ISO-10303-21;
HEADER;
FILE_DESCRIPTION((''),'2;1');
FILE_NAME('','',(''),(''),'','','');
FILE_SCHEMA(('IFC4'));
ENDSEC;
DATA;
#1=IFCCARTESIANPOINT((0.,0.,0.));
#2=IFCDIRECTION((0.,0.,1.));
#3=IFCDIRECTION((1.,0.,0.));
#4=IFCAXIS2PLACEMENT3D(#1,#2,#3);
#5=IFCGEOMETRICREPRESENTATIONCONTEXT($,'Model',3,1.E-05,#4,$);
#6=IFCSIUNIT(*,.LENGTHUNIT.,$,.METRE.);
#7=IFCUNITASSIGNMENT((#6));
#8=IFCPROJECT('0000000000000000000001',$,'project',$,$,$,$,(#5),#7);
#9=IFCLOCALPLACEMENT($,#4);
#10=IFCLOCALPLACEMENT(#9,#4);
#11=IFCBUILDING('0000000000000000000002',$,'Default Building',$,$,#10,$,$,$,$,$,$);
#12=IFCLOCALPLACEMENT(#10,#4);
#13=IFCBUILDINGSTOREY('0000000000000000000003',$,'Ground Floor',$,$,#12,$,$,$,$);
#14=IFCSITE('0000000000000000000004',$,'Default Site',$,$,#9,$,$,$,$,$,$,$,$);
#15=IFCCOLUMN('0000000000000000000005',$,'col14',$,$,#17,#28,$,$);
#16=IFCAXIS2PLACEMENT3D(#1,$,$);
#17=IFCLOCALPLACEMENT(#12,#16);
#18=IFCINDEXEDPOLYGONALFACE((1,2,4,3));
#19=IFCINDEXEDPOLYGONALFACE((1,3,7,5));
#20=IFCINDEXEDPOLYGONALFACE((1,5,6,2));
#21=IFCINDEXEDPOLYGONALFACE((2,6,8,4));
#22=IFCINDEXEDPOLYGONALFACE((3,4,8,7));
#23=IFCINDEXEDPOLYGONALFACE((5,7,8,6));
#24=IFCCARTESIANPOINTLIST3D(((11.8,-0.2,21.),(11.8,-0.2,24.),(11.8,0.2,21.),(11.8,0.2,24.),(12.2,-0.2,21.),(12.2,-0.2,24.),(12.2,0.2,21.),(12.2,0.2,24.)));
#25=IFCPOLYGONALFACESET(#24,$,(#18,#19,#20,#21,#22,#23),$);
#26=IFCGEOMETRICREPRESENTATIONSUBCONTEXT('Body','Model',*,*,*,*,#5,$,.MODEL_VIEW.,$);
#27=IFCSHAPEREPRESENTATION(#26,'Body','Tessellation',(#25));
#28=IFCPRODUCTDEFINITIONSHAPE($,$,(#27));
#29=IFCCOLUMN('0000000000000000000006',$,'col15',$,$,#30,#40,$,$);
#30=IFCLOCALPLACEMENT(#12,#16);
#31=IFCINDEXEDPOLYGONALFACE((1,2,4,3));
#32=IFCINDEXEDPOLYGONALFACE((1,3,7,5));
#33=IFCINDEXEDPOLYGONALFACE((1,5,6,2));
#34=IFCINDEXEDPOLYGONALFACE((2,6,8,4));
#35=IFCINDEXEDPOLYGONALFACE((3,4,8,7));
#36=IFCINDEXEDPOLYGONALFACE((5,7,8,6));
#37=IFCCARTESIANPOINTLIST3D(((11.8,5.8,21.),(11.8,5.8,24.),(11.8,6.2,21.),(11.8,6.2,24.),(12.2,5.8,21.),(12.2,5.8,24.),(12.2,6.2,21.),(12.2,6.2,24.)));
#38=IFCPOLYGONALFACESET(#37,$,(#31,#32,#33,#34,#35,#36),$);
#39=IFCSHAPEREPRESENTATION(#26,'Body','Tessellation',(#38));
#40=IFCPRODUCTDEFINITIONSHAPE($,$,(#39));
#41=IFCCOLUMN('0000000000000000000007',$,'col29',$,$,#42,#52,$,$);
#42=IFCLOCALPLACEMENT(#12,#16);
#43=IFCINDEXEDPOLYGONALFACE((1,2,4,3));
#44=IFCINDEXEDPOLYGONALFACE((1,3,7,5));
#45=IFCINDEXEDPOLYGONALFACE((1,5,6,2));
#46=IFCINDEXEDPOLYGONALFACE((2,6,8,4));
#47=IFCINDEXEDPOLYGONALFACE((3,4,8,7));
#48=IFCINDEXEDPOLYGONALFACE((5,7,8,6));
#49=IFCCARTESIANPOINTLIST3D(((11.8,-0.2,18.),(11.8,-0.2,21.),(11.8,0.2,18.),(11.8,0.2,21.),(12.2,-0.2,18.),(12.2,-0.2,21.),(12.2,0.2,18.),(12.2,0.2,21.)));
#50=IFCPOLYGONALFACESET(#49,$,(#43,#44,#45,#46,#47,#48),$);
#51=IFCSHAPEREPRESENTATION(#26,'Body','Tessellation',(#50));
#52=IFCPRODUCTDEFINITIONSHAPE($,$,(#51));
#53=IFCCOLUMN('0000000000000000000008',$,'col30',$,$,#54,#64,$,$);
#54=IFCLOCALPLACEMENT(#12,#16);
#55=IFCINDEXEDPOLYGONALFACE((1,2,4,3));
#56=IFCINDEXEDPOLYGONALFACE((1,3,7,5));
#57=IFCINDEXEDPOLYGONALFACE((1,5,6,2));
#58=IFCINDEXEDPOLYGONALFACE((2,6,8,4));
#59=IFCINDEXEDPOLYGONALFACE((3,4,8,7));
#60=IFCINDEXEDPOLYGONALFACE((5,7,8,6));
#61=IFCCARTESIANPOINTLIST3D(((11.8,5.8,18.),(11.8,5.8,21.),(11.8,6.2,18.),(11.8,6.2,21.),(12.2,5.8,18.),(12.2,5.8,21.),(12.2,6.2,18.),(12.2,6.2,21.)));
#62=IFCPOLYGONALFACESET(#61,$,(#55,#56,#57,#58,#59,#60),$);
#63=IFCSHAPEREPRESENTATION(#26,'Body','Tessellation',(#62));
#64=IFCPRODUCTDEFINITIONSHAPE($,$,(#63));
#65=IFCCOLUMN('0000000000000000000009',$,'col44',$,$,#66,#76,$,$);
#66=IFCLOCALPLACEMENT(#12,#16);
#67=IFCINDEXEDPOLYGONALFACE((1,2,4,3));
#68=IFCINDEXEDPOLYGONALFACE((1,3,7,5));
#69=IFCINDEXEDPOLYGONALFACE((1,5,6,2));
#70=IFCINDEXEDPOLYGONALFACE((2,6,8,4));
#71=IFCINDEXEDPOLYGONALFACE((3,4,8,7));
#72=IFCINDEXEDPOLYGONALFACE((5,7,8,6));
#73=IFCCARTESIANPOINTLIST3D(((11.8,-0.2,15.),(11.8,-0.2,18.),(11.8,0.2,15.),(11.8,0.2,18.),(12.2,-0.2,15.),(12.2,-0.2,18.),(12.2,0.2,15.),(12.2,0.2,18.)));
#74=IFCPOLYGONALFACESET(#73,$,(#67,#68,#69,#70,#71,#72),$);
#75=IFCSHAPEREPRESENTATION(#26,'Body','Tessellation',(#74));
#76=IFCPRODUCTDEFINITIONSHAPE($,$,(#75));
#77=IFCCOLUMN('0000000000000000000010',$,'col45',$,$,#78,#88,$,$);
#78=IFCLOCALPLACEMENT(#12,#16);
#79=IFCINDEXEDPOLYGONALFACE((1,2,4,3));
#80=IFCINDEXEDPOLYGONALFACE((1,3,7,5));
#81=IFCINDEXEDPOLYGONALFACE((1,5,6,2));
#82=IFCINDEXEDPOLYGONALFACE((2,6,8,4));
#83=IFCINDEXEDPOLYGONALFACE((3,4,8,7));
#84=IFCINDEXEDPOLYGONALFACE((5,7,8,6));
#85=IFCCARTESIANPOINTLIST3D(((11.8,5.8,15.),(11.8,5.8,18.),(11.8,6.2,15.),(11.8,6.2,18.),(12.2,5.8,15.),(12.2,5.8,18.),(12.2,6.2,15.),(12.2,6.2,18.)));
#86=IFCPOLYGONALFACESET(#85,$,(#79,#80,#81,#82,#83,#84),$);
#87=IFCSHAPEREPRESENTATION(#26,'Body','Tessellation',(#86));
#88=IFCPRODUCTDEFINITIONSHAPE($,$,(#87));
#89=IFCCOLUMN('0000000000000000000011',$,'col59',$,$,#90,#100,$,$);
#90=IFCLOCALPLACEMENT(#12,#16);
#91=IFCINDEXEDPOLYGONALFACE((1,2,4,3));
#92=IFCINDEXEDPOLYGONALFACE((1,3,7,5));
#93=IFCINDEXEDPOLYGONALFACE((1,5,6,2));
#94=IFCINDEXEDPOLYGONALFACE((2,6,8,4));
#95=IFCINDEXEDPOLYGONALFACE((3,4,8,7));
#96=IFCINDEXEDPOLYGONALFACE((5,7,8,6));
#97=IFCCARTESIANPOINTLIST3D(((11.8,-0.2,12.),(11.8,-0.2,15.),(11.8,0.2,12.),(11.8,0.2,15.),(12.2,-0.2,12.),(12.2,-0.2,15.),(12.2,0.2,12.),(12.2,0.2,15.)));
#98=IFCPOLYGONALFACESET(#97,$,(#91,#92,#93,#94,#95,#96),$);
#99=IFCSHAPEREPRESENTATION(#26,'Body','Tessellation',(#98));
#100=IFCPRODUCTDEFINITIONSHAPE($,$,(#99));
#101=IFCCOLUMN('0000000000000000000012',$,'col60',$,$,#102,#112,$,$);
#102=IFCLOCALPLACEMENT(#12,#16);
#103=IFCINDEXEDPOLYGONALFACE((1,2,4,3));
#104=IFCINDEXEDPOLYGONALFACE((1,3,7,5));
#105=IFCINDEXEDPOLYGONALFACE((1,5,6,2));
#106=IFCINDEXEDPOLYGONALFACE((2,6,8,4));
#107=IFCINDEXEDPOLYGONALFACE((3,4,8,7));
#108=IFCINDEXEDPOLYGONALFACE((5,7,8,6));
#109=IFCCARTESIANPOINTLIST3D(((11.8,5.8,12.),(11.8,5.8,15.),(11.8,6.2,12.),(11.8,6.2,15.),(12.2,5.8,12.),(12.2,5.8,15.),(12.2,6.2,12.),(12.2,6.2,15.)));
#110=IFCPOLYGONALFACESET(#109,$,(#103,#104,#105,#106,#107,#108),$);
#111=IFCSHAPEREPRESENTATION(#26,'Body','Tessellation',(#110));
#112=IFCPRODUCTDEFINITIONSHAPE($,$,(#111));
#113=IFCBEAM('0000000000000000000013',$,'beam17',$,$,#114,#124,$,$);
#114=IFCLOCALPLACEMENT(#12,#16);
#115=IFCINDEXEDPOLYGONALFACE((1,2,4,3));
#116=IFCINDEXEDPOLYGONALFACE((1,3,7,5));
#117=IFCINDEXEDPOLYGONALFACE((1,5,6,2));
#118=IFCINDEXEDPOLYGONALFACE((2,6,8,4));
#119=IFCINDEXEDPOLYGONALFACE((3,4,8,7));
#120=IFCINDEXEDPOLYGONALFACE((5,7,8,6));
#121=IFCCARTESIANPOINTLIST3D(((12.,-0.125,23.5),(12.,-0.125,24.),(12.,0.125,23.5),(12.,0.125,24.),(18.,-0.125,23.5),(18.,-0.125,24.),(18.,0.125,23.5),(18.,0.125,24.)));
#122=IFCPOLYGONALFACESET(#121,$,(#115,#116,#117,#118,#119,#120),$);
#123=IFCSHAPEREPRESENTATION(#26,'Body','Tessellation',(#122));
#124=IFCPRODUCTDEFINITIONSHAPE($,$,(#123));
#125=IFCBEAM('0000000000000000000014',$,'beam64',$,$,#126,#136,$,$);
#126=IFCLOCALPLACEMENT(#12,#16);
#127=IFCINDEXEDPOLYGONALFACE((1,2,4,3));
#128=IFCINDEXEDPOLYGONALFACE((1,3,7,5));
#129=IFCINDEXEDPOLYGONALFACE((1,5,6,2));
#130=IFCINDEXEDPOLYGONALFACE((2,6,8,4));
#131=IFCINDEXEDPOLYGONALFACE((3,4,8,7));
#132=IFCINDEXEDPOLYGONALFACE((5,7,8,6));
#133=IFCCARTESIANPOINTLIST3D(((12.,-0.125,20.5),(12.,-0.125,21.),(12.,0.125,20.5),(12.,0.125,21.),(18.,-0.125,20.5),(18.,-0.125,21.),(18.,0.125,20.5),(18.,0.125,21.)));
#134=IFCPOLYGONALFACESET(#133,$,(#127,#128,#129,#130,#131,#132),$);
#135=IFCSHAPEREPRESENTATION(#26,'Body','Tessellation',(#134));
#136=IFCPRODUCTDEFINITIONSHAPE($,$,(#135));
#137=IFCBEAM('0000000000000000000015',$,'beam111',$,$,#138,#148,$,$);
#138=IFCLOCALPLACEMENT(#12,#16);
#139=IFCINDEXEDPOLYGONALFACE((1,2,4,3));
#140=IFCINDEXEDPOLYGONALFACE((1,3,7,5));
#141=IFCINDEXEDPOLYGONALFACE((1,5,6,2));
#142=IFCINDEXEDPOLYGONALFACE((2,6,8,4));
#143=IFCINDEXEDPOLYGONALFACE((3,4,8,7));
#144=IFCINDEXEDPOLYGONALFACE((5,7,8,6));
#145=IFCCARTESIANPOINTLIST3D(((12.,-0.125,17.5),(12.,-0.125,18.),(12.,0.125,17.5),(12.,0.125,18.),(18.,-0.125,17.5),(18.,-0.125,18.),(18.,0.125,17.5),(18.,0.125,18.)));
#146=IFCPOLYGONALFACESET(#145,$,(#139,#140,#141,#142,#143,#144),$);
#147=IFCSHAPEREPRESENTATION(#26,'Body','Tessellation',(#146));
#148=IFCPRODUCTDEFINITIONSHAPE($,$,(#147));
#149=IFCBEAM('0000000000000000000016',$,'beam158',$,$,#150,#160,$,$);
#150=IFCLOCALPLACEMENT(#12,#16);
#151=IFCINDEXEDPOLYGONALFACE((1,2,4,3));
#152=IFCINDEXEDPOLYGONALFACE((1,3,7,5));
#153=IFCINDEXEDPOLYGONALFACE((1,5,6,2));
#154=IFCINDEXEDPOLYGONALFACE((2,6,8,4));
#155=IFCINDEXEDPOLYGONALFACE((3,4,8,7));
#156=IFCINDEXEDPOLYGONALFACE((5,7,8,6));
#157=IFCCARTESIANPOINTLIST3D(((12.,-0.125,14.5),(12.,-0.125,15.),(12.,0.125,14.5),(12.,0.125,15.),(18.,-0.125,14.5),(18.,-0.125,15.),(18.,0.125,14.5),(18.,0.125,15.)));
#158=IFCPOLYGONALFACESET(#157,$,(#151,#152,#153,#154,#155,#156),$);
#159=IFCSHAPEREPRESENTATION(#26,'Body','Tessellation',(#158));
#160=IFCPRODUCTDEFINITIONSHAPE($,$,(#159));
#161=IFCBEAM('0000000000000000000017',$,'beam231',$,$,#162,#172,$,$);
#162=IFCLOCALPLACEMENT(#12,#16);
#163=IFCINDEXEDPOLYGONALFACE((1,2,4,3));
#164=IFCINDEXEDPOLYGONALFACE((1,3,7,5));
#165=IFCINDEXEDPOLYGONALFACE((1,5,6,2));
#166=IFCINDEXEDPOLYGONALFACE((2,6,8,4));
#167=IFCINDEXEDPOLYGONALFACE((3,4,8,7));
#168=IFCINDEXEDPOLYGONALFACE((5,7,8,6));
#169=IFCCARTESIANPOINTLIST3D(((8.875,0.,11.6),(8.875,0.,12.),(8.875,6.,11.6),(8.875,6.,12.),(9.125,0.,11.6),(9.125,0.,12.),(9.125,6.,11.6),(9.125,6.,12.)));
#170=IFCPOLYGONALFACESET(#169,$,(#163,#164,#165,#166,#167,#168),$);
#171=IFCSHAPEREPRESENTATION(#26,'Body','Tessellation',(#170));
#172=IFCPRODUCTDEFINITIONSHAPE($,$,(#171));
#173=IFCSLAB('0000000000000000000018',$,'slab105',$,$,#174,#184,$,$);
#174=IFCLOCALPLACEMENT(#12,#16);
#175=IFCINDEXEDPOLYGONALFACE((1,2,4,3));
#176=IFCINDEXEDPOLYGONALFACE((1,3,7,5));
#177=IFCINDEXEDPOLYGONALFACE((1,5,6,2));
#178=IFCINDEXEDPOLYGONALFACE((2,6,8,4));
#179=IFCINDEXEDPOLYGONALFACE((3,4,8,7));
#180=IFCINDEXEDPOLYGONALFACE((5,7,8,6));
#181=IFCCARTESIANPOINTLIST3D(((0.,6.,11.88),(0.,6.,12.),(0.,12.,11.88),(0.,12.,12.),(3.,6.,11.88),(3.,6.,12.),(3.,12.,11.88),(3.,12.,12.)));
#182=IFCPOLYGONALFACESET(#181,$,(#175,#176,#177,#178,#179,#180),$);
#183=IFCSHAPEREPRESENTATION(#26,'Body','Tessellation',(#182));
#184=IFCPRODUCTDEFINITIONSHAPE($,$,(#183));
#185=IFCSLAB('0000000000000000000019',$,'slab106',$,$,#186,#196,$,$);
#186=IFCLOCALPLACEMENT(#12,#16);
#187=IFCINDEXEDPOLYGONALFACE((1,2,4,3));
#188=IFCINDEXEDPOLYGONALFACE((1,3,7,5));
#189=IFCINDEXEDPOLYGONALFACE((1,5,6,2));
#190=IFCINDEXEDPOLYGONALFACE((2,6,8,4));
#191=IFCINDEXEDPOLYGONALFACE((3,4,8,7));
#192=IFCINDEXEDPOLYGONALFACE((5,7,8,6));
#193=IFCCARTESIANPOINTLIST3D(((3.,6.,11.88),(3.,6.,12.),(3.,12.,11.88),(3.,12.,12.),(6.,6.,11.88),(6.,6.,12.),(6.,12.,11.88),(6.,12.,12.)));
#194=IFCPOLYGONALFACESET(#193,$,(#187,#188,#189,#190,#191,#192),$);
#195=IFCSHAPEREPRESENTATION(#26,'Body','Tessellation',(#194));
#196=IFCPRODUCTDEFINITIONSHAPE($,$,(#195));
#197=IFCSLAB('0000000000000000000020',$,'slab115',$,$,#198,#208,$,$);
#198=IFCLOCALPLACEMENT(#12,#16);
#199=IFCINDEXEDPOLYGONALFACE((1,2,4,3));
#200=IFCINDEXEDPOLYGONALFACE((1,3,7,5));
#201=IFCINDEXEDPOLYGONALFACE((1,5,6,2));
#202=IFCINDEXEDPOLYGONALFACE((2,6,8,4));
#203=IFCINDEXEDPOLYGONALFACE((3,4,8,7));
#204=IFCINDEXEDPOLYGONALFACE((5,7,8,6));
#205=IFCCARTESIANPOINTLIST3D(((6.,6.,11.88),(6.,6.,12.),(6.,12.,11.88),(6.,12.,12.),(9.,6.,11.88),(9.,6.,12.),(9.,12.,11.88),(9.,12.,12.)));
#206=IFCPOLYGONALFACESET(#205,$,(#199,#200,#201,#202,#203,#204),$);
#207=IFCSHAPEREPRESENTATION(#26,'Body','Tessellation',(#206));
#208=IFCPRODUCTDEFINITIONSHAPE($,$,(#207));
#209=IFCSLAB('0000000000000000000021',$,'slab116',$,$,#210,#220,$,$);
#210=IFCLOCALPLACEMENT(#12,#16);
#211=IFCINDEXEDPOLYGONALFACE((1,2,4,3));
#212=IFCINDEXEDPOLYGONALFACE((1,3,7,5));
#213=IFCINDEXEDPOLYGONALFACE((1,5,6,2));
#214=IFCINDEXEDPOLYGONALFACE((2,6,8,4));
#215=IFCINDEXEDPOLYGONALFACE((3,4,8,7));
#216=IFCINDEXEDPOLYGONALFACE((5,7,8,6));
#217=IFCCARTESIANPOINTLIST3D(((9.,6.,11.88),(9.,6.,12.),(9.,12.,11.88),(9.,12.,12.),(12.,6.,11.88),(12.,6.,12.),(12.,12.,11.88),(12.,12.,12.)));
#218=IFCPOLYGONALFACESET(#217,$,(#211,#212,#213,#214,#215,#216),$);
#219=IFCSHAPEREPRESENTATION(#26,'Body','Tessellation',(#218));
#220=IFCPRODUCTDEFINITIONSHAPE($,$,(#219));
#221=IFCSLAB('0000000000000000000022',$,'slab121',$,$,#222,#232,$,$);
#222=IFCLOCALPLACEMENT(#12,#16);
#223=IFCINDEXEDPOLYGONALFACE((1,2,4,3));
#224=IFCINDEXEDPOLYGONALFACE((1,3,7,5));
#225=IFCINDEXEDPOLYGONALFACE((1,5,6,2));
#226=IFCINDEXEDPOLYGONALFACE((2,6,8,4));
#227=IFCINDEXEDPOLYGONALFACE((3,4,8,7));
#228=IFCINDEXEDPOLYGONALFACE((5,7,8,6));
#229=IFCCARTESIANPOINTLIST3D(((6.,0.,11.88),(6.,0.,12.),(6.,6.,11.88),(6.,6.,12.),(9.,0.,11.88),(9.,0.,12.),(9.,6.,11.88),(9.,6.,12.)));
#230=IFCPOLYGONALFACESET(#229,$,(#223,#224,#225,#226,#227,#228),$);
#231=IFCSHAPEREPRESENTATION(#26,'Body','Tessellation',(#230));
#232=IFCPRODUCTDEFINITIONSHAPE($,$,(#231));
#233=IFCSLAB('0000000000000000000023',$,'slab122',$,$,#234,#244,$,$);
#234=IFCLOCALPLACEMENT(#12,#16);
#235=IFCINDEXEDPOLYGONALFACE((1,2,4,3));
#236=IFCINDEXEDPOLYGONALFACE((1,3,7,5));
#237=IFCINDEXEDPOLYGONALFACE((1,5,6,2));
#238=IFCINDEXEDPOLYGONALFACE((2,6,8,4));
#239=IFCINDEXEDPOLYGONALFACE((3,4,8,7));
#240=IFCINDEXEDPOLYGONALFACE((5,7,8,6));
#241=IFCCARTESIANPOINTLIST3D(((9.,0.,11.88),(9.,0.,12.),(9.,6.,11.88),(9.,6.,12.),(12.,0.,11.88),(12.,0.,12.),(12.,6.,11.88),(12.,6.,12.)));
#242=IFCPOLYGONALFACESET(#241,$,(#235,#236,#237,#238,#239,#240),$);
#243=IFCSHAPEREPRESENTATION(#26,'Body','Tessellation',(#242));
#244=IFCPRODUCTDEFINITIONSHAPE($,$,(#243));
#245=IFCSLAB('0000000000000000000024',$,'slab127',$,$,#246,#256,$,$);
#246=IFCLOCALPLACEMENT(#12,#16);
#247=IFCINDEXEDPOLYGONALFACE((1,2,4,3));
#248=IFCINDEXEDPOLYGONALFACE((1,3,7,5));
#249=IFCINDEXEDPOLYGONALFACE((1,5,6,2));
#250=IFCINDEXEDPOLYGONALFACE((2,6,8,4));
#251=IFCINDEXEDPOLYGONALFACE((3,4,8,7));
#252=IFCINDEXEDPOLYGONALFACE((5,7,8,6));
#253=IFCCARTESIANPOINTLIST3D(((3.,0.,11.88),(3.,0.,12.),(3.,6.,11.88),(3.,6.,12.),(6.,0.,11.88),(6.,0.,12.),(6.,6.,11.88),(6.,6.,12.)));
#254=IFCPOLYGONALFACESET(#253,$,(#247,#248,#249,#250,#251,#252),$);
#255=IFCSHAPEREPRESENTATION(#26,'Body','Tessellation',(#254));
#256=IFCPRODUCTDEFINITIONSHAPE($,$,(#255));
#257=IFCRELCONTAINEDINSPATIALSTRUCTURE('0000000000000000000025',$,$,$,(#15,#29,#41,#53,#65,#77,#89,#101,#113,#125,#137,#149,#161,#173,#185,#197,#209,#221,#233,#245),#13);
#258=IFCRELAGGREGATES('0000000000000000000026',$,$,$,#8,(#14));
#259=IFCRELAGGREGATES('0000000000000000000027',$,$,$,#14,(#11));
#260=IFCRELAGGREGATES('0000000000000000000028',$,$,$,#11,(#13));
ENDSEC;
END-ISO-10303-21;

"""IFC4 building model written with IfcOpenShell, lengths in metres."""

from ifc_helpers import new_model, si_unit, frame, origin_with_axes, place, context, subcontext, project, spatial, indexed_curve, outline, extrude, element, save


model = new_model("IFC4")

# Units and contexts
model_context = context("Model", 3, precision=1e-05, world=origin_with_axes())
body_context = subcontext(model_context, "Body", "Model", "MODEL_VIEW")
ifc_project = project(units=[si_unit("LENGTHUNIT", "METRE")], contexts=[model_context])

# Site, building, storey
site_placement = place(None, origin_with_axes())
site = spatial("IfcSite", under=ifc_project, at=site_placement, Name="Default Site")
building_placement = place(site_placement, origin_with_axes())
building = spatial("IfcBuilding", under=site, at=building_placement, Name="Default Building")
storey_placement = place(building_placement, origin_with_axes())
storey = spatial("IfcBuildingStorey", under=building, at=storey_placement, Name="Ground Floor")

# Columns
for number, where, z_axis, x_axis, name in (
    (1, (11.8, -0.2, 21.0), (0.0, 0.0, 1.0), (1.0, 0.0, 0.0), "col14"),
    (2, (11.8, 5.8, 21.0), (0.0, 0.0, 1.0), (1.0, 0.0, 0.0), "col15"),
    (3, (11.8, -0.2, 18.0), (0.0, 0.0, 1.0), (1.0, 0.0, 0.0), "col29"),
    (4, (11.8, 5.8, 18.0), (0.0, 0.0, 1.0), (1.0, 0.0, 0.0), "col30"),
    (5, (11.8, -0.2, 15.0), (0.0, 0.0, 1.0), (1.0, 0.0, 0.0), "col44"),
    (6, (11.8, 5.8, 15.0), (0.0, 0.0, 1.0), (1.0, 0.0, 0.0), "col45"),
    (7, (11.8, -0.2, 12.0), (0.0, 0.0, 1.0), (1.0, 0.0, 0.0), "col59"),
    (8, (11.8, 5.8, 12.0), (0.0, 0.0, 1.0), (1.0, 0.0, 0.0), "col60"),
):
    element("IfcColumn", number, at=place(storey_placement, frame(where, z_axis=z_axis, x_axis=x_axis)), inside=storey, Name=name, context=body_context, shape_type="SweptSolid", body=[
        extrude(outline(indexed_curve([(0.0, 0.0), (0.0, 0.4), (0.4, 0.4), (0.4, 0.0), (0.0, 0.0)], self_intersect=False)), origin_with_axes(), (0.0, 0.0, 1.0), 3.0),
    ])

# Beams
for number, where, z_axis, x_axis, name in (
    (9, (12.0, -0.125, 23.5), (0.0, 0.0, 1.0), (1.0, 0.0, 0.0), "beam17"),
    (10, (12.0, -0.125, 20.5), (0.0, 0.0, 1.0), (1.0, 0.0, 0.0), "beam64"),
    (11, (12.0, -0.125, 17.5), (0.0, 0.0, 1.0), (1.0, 0.0, 0.0), "beam111"),
    (12, (12.0, -0.125, 14.5), (0.0, 0.0, 1.0), (1.0, 0.0, 0.0), "beam158"),
):
    element("IfcBeam", number, at=place(storey_placement, frame(where, z_axis=z_axis, x_axis=x_axis)), inside=storey, Name=name, context=body_context, shape_type="SweptSolid", body=[
        extrude(outline(indexed_curve([(0.0, 0.0), (0.0, 0.25), (6.0, 0.25), (6.0, 0.0), (0.0, 0.0)], self_intersect=False)), origin_with_axes(), (0.0, 0.0, 1.0), 0.5),
    ])
beam_placement = place(storey_placement, frame((8.875, 6.0, 11.6), z_axis=(0.0, 0.0, 1.0), x_axis=(0.0, -1.0, 0.0)))
element("IfcBeam", 13, at=beam_placement, inside=storey, Name="beam231", context=body_context, shape_type="SweptSolid", body=[
    extrude(outline(indexed_curve([(0.0, 0.0), (0.0, 0.25), (6.0, 0.25), (6.0, 0.0), (0.0, 0.0)], self_intersect=False)), origin_with_axes(), (0.0, 0.0, 1.0), 0.4),
])

# Slabs
for number, where, z_axis, x_axis, name in (
    (14, (0.0, 6.0, 11.88), (0.0, 0.0, 1.0), (1.0, 0.0, 0.0), "slab105"),
    (15, (3.0, 6.0, 11.88), (0.0, 0.0, 1.0), (1.0, 0.0, 0.0), "slab106"),
    (16, (6.0, 6.0, 11.88), (0.0, 0.0, 1.0), (1.0, 0.0, 0.0), "slab115"),
    (17, (9.0, 6.0, 11.88), (0.0, 0.0, 1.0), (1.0, 0.0, 0.0), "slab116"),
    (18, (6.0, 0.0, 11.88), (0.0, 0.0, 1.0), (1.0, 0.0, 0.0), "slab121"),
    (19, (9.0, 0.0, 11.88), (0.0, 0.0, 1.0), (1.0, 0.0, 0.0), "slab122"),
    (20, (3.0, 0.0, 11.88), (0.0, 0.0, 1.0), (1.0, 0.0, 0.0), "slab127"),
):
    element("IfcSlab", number, at=place(storey_placement, frame(where, z_axis=z_axis, x_axis=x_axis)), inside=storey, Name=name, context=body_context, shape_type="SweptSolid", body=[
        extrude(outline(indexed_curve([(0.0, 0.0), (0.0, 6.0), (3.0, 6.0), (3.0, 0.0), (0.0, 0.0)], self_intersect=False)), origin_with_axes(), (0.0, 0.0, 1.0), 0.12),
    ])

save(model, "model.ifc")
